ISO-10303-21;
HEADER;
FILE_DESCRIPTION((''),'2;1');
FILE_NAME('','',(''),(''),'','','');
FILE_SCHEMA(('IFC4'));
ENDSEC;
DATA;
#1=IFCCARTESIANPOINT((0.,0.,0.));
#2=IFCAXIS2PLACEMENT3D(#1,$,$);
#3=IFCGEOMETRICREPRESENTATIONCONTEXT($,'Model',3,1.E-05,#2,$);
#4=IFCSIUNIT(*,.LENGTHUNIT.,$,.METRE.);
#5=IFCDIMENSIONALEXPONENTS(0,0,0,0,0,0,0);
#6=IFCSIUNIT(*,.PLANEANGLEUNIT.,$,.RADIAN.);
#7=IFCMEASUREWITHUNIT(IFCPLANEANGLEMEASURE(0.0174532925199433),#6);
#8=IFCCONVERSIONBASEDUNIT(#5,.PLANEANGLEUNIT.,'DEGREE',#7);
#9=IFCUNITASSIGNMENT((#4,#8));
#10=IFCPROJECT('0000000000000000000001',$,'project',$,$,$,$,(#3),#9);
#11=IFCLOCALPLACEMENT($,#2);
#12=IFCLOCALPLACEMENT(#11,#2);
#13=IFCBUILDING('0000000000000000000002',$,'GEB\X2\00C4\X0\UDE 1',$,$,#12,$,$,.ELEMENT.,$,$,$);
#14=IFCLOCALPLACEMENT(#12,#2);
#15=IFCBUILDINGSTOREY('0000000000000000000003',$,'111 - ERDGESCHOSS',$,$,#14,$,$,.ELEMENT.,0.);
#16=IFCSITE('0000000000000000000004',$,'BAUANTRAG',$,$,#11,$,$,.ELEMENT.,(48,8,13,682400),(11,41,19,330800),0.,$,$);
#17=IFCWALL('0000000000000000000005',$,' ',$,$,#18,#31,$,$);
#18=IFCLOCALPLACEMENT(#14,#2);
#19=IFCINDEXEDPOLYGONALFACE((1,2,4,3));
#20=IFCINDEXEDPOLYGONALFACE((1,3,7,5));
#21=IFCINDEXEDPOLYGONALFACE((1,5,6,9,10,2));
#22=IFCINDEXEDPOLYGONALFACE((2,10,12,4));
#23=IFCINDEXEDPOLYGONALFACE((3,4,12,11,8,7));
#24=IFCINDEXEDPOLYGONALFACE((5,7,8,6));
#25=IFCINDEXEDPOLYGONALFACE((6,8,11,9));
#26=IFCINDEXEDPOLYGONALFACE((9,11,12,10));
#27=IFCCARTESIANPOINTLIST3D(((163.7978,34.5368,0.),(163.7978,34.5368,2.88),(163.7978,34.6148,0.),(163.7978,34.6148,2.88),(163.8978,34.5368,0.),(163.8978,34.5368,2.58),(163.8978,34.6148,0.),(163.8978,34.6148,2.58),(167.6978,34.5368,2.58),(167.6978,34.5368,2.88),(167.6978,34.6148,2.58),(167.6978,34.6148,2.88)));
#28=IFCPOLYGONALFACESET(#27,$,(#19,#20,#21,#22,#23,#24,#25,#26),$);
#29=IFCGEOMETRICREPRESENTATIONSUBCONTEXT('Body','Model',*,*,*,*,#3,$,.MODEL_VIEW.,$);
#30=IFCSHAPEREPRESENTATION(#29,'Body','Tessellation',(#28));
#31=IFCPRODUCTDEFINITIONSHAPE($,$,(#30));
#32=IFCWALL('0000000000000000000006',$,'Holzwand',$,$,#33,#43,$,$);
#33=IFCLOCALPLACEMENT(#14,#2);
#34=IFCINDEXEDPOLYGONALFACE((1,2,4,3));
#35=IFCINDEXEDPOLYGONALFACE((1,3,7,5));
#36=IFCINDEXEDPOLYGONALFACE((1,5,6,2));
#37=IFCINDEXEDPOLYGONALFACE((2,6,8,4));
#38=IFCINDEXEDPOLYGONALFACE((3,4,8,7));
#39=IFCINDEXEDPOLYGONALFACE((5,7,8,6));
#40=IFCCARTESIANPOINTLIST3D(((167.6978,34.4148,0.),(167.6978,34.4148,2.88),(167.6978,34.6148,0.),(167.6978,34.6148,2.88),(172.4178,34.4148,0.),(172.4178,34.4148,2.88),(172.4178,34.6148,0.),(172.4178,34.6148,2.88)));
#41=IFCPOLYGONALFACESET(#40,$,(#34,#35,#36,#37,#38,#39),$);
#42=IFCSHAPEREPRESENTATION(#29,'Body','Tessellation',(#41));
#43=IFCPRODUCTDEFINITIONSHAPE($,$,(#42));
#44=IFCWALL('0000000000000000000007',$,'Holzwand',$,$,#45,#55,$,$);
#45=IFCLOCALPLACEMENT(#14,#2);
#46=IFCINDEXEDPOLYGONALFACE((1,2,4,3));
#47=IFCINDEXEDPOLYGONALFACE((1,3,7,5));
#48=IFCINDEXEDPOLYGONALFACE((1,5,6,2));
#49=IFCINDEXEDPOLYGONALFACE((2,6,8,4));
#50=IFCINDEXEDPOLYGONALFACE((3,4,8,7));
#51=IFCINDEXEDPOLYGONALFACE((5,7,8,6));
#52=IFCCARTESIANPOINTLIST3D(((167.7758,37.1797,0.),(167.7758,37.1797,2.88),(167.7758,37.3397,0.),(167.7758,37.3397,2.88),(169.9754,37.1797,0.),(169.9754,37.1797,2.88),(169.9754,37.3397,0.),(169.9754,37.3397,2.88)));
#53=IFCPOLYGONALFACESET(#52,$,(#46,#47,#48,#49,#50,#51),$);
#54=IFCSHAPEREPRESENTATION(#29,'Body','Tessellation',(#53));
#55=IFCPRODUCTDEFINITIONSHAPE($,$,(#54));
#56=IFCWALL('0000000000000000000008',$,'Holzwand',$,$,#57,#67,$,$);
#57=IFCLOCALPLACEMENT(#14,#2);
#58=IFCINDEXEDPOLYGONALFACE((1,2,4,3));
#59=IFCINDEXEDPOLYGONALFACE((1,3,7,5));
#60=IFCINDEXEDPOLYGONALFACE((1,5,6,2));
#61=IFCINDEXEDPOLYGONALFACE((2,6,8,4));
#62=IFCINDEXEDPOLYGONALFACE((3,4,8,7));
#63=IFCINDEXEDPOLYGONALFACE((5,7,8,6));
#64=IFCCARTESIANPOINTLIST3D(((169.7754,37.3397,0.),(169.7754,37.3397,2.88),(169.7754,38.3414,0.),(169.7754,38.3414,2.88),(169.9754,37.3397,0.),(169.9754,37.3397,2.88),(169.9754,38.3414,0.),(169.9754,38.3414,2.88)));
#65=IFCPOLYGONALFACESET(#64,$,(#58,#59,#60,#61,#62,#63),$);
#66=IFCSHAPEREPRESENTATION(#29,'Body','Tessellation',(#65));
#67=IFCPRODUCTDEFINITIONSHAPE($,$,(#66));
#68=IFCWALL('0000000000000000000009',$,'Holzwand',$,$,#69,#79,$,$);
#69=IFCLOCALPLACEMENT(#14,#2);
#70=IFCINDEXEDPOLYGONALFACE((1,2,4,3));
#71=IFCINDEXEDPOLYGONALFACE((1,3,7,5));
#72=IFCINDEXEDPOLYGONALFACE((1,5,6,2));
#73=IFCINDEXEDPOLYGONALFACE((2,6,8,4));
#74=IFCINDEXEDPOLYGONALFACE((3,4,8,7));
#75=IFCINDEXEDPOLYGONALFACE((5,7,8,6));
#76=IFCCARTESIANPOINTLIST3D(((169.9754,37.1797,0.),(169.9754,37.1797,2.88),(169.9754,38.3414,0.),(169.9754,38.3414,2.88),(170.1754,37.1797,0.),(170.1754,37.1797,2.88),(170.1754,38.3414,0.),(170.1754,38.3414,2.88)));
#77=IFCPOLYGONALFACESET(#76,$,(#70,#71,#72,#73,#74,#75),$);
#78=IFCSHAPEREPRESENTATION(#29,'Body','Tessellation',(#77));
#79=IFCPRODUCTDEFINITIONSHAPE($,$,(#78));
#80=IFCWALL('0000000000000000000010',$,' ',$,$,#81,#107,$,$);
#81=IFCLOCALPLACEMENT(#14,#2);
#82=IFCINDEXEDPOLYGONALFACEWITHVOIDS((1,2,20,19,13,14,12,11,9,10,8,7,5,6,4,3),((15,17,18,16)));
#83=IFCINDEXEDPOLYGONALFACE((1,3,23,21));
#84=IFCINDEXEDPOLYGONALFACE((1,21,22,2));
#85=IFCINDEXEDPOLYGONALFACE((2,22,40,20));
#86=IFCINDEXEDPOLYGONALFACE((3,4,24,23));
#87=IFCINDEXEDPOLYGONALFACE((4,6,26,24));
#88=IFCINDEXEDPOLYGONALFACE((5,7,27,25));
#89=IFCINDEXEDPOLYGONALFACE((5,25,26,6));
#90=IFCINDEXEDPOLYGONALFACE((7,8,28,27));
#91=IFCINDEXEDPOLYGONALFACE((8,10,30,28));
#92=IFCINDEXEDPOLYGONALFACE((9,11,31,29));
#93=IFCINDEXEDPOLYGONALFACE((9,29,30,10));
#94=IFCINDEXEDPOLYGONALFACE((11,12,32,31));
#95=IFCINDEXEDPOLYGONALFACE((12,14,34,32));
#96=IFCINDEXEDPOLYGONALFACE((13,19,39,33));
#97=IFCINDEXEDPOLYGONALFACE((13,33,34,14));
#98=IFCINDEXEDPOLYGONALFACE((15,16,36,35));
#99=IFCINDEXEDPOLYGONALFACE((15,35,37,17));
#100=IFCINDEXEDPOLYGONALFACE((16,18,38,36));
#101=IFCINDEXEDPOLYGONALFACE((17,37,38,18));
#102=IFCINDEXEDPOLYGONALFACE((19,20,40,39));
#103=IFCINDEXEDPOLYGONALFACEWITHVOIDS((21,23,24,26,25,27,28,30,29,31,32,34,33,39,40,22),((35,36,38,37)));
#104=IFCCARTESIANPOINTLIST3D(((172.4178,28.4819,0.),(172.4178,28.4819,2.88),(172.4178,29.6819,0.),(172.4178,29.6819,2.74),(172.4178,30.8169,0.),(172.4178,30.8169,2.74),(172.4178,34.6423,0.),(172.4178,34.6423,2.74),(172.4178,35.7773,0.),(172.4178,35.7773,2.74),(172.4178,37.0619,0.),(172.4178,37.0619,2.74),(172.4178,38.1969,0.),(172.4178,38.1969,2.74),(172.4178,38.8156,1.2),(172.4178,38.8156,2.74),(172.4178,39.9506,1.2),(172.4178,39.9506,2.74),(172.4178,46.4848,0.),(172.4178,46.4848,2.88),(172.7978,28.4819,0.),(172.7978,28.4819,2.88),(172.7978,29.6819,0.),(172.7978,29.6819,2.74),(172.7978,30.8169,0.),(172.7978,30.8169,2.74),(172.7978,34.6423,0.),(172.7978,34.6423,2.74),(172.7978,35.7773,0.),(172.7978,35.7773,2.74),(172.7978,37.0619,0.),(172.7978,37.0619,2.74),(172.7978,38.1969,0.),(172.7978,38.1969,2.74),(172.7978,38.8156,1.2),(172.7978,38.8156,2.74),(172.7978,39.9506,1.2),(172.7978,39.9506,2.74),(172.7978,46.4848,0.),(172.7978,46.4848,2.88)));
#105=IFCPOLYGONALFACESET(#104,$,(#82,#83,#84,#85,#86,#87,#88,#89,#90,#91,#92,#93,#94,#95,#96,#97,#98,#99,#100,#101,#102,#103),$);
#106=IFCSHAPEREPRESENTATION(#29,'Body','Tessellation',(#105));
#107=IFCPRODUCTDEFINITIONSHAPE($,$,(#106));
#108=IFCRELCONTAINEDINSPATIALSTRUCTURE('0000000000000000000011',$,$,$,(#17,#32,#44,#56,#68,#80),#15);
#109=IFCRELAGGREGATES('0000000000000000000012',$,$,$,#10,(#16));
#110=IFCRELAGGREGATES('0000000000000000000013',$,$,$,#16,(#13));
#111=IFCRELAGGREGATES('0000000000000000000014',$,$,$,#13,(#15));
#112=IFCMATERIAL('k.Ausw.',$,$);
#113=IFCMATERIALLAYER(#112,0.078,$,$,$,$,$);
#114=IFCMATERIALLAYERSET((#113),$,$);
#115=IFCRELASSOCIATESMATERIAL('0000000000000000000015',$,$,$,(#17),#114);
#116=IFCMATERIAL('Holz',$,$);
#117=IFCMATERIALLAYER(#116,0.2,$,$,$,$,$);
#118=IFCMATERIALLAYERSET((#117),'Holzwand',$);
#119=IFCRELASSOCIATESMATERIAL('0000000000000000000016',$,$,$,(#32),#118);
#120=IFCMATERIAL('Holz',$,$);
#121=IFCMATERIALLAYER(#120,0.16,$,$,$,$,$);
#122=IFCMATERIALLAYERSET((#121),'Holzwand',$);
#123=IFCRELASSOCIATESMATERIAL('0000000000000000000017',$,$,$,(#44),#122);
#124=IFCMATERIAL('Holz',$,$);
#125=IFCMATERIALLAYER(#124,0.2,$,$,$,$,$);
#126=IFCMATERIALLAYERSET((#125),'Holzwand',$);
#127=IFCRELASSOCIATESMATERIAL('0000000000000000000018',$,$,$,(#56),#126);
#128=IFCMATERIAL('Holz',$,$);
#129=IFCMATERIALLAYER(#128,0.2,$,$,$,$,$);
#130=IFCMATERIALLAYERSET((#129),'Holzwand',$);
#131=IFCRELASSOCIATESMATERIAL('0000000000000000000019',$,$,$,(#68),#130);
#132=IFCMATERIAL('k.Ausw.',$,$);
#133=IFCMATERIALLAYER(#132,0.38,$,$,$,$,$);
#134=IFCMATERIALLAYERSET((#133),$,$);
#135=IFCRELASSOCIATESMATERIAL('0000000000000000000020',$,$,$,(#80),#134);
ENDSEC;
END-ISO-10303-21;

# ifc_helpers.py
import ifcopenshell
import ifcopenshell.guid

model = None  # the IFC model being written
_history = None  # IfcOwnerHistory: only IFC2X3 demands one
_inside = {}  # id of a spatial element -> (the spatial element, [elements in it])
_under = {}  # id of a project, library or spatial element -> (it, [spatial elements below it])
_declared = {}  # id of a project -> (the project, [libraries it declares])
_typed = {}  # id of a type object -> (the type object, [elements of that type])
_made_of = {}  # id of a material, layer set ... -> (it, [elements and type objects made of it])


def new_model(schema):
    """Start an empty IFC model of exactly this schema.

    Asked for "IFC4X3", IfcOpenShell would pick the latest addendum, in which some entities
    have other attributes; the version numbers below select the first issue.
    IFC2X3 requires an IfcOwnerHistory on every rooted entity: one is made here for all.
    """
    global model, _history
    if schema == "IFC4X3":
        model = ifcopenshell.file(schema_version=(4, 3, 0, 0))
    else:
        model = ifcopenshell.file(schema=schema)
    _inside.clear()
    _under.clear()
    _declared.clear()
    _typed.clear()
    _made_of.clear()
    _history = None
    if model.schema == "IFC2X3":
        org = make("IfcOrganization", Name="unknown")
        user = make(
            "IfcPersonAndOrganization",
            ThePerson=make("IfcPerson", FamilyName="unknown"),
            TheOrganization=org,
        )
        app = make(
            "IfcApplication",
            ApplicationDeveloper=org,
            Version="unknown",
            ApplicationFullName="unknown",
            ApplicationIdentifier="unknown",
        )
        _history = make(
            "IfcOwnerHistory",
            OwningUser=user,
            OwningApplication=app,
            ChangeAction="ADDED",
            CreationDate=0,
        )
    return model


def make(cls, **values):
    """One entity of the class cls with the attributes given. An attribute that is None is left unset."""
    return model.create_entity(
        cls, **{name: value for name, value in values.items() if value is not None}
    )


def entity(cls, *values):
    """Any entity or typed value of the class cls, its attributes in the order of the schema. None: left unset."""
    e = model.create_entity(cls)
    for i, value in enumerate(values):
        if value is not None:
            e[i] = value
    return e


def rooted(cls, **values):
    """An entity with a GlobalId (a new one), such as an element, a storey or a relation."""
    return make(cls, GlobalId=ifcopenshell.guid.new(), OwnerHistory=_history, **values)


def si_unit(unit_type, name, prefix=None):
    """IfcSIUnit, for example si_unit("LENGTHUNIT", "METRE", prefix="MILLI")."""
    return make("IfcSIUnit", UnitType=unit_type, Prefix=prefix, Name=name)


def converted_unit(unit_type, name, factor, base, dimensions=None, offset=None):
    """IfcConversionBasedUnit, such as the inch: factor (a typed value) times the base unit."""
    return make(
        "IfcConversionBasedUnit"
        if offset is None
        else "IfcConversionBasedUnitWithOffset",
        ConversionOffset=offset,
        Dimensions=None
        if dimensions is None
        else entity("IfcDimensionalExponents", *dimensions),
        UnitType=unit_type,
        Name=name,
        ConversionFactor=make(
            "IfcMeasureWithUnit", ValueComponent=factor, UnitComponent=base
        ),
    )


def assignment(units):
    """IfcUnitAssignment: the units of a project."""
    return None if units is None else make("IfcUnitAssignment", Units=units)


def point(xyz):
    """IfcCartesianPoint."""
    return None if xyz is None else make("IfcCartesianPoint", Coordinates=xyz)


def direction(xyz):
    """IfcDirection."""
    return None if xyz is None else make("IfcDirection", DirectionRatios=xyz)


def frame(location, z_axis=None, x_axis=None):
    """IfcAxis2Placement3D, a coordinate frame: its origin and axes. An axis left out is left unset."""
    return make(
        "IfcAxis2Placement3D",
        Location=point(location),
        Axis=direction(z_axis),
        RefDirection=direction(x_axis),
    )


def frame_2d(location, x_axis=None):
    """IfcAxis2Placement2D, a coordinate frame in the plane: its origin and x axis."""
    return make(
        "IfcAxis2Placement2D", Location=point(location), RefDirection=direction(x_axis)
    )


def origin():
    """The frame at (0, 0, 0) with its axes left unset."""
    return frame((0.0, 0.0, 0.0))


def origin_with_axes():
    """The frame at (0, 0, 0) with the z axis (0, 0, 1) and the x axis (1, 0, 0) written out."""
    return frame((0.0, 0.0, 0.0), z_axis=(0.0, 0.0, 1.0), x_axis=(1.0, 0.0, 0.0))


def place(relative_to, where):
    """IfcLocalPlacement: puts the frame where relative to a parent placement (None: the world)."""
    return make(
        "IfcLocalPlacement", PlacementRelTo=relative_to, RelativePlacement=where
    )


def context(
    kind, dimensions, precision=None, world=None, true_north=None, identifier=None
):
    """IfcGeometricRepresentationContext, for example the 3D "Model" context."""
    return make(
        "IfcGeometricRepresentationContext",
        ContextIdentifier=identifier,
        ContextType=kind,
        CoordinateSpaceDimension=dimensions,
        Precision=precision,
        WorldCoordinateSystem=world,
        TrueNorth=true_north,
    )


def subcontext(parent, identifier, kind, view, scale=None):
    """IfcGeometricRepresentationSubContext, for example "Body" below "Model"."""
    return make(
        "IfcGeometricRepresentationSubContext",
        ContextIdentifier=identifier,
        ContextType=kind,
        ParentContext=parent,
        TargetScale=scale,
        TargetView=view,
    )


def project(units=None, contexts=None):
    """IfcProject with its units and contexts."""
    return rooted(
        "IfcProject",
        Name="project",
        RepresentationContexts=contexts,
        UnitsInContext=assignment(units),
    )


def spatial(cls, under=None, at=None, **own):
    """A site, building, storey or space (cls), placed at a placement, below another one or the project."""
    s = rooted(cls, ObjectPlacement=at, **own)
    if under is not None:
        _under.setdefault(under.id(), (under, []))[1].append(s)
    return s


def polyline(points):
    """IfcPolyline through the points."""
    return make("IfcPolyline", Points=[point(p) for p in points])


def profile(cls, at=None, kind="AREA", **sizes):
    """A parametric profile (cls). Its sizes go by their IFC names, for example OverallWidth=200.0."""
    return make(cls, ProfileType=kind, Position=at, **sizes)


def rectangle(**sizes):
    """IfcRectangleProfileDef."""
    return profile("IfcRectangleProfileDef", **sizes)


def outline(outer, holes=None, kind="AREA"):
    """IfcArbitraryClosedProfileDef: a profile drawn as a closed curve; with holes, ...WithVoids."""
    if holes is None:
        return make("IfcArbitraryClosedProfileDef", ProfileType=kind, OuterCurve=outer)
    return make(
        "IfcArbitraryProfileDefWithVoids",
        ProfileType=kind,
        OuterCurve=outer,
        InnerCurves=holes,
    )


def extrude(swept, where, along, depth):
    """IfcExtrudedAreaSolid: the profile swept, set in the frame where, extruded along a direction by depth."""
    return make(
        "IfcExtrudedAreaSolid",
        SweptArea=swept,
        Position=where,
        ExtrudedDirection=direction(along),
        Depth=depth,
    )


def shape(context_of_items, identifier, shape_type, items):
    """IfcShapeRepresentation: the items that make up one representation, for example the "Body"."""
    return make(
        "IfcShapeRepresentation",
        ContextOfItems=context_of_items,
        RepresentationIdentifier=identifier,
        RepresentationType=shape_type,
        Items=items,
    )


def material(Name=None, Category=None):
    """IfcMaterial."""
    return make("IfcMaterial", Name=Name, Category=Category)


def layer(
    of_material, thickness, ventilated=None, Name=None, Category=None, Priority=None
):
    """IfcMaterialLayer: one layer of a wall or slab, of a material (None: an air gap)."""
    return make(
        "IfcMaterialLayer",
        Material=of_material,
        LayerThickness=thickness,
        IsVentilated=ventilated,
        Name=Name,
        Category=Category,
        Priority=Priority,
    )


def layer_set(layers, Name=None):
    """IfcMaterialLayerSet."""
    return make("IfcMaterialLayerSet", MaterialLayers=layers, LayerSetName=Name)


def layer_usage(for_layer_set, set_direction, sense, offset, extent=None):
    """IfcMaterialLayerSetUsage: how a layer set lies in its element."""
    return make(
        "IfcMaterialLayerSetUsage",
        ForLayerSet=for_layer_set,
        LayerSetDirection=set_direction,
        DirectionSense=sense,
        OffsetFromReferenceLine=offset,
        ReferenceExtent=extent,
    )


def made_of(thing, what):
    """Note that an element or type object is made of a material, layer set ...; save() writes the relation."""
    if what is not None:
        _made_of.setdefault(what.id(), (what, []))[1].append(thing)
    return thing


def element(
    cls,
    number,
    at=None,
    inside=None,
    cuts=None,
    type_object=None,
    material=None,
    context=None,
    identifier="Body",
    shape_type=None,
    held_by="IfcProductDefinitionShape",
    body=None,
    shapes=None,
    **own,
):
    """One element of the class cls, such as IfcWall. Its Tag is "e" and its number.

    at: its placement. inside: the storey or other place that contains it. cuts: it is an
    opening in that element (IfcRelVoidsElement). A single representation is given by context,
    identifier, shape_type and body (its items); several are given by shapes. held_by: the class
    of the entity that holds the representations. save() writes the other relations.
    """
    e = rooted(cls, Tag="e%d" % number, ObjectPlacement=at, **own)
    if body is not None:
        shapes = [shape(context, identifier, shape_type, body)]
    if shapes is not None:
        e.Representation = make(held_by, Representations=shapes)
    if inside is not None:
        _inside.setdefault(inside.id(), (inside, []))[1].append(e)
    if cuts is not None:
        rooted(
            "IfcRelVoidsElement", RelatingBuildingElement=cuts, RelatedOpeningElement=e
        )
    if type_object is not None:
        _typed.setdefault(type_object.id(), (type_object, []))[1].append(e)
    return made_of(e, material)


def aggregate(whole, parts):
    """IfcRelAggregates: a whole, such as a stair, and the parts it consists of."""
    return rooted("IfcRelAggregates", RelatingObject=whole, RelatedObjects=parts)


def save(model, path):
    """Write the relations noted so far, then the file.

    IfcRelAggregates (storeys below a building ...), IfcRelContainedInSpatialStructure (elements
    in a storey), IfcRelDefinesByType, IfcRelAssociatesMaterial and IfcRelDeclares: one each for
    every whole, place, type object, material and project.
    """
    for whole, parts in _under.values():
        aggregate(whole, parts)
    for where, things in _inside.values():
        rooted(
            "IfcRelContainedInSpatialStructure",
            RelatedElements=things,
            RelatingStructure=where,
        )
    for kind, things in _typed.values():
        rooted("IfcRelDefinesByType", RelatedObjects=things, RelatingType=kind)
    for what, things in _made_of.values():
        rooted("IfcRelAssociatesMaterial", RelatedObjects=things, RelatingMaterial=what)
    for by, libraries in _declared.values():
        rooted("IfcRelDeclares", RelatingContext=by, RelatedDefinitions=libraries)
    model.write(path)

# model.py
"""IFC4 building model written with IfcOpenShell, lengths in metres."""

from ifc_helpers import new_model, entity, si_unit, converted_unit, frame, frame_2d, origin, origin_with_axes, place, context, subcontext, project, spatial, polyline, rectangle, outline, extrude, material, layer, layer_set, layer_usage, element, save


model = new_model("IFC4")

# Units and contexts
model_context = context("Model", 3, precision=1e-05, world=origin())
body_context = subcontext(model_context, "Body", "Model", "MODEL_VIEW")
ifc_project = project(units=[si_unit("LENGTHUNIT", "METRE"), converted_unit("PLANEANGLEUNIT", "DEGREE", entity("IfcPlaneAngleMeasure", 0.0174532925199433), si_unit("PLANEANGLEUNIT", "RADIAN"), dimensions=[0, 0, 0, 0, 0, 0, 0])], contexts=[model_context])

# Site, building, storey
site_placement = place(None, origin())
site = spatial("IfcSite", under=ifc_project, at=site_placement, Name="BAUANTRAG", CompositionType="ELEMENT", RefLatitude=(48, 8, 13, 682400), RefLongitude=(11, 41, 19, 330800), RefElevation=0.0)
building_placement = place(site_placement, origin())
building = spatial("IfcBuilding", under=site, at=building_placement, Name="GEBÄUDE 1", CompositionType="ELEMENT")
storey_placement = place(building_placement, origin())
storey = spatial("IfcBuildingStorey", under=building, at=storey_placement, Name="111 - ERDGESCHOSS", CompositionType="ELEMENT", Elevation=0.0)

# Wall, opening
ifc_material_1 = material(Name="k.Ausw.")
ifc_layer_1 = layer(ifc_material_1, 0.078)
ifc_layer_set_1 = layer_set([ifc_layer_1])
ifc_layer_usage_1 = layer_usage(ifc_layer_set_1, "AXIS2", "POSITIVE", 0.0)
wall_1_placement = place(storey_placement, frame((163.7978, 34.5368, 0.0)))
wall_1 = element("IfcWall", 1, at=wall_1_placement, inside=storey, material=ifc_layer_usage_1, Name=" ", context=body_context, shape_type="SweptSolid", body=[
    extrude(rectangle(XDim=3.9, YDim=0.078, at=frame_2d((1.95, 0.039), x_axis=(1.0, 0.0))), origin_with_axes(), (0.0, 0.0, 1.0), 2.88),
])
opening_1_placement = place(wall_1_placement, frame((0.1, 0.0, -0.14), z_axis=(0.0, 1.0, 0.0), x_axis=(0.0, 0.0, 1.0)))
element("IfcOpeningElement", 2, at=opening_1_placement, cuts=wall_1, ObjectType="Opening", context=body_context, shape_type="SweptSolid", body=[
    extrude(outline(polyline([(0.0, 3.8), (2.72, 3.8), (2.72, 0.0), (0.0, 0.0), (0.0, 3.8)])), origin_with_axes(), (0.0, 0.0, 1.0), 0.078),
])

# Walls
ifc_material_2 = material(Name="Holz")
ifc_layer_2 = layer(ifc_material_2, 0.2)
ifc_layer_set_2 = layer_set([ifc_layer_2], Name="Holzwand")
ifc_layer_usage_2 = layer_usage(ifc_layer_set_2, "AXIS2", "POSITIVE", 0.0)
wall_2_placement = place(storey_placement, frame((167.6978, 34.4148, 0.0)))
element("IfcWall", 3, at=wall_2_placement, inside=storey, material=ifc_layer_usage_2, Name="Holzwand", context=body_context, shape_type="SweptSolid", body=[
    extrude(rectangle(XDim=4.72, YDim=0.2, at=frame_2d((2.36, 0.1), x_axis=(1.0, 0.0))), origin_with_axes(), (0.0, 0.0, 1.0), 2.88),
])
ifc_material_3 = material(Name="Holz")
ifc_layer_3 = layer(ifc_material_3, 0.16)
ifc_layer_set_3 = layer_set([ifc_layer_3], Name="Holzwand")
ifc_layer_usage_3 = layer_usage(ifc_layer_set_3, "AXIS2", "POSITIVE", 0.0)
wall_3_placement = place(storey_placement, frame((169.9754, 37.3397, 0.0), z_axis=(0.0, 0.0, 1.0), x_axis=(-1.0, 0.0, 0.0)))
element("IfcWall", 4, at=wall_3_placement, inside=storey, material=ifc_layer_usage_3, Name="Holzwand", context=body_context, shape_type="SweptSolid", body=[
    extrude(rectangle(XDim=2.1997, YDim=0.16, at=frame_2d((1.0998, 0.08), x_axis=(1.0, 0.0))), origin_with_axes(), (0.0, 0.0, 1.0), 2.88),
])
ifc_material_4 = material(Name="Holz")
ifc_layer_4 = layer(ifc_material_4, 0.2)
ifc_layer_set_4 = layer_set([ifc_layer_4], Name="Holzwand")
ifc_layer_usage_4 = layer_usage(ifc_layer_set_4, "AXIS2", "POSITIVE", 0.0)
wall_4_placement = place(storey_placement, frame((169.9754, 37.3397, 0.0), z_axis=(0.0, 0.0, 1.0), x_axis=(0.0, 1.0, 0.0)))
element("IfcWall", 5, at=wall_4_placement, inside=storey, material=ifc_layer_usage_4, Name="Holzwand", context=body_context, shape_type="SweptSolid", body=[
    extrude(rectangle(XDim=1.0017, YDim=0.2, at=frame_2d((0.5008, 0.1), x_axis=(1.0, 0.0))), origin_with_axes(), (0.0, 0.0, 1.0), 2.88),
])
ifc_material_5 = material(Name="Holz")
ifc_layer_5 = layer(ifc_material_5, 0.2)
ifc_layer_set_5 = layer_set([ifc_layer_5], Name="Holzwand")
ifc_layer_usage_5 = layer_usage(ifc_layer_set_5, "AXIS2", "POSITIVE", 0.0)
wall_5_placement = place(storey_placement, frame((170.1754, 37.1797, 0.0), z_axis=(0.0, 0.0, 1.0), x_axis=(0.0, 1.0, 0.0)))
element("IfcWall", 6, at=wall_5_placement, inside=storey, material=ifc_layer_usage_5, Name="Holzwand", context=body_context, shape_type="SweptSolid", body=[
    extrude(rectangle(XDim=1.1617, YDim=0.2, at=frame_2d((0.5808, 0.1), x_axis=(1.0, 0.0))), origin_with_axes(), (0.0, 0.0, 1.0), 2.88),
])

# Wall, openings
ifc_material_6 = material(Name="k.Ausw.")
ifc_layer_6 = layer(ifc_material_6, 0.38)
ifc_layer_set_6 = layer_set([ifc_layer_6])
ifc_layer_usage_6 = layer_usage(ifc_layer_set_6, "AXIS2", "POSITIVE", 0.0)
wall_6_placement = place(storey_placement, frame((172.7978, 28.4819, 0.0), z_axis=(0.0, 0.0, 1.0), x_axis=(0.0, 1.0, 0.0)))
wall_6 = element("IfcWall", 7, at=wall_6_placement, inside=storey, material=ifc_layer_usage_6, Name=" ", context=body_context, shape_type="SweptSolid", body=[
    extrude(rectangle(XDim=18.0029, YDim=0.38, at=frame_2d((9.0014, 0.19), x_axis=(1.0, 0.0))), origin_with_axes(), (0.0, 0.0, 1.0), 2.88),
])
opening_2_placement = place(wall_6_placement, frame((10.3337, 0.0, 1.2), z_axis=(0.0, 1.0, 0.0), x_axis=(0.0, 0.0, 1.0)))
element("IfcOpeningElement", 8, at=opening_2_placement, cuts=wall_6, ObjectType="Opening", context=body_context, shape_type="SweptSolid", body=[
    extrude(outline(polyline([(0.0, 1.135), (1.54, 1.135), (1.54, 0.0), (0.0, 0.0), (0.0, 1.135)])), origin_with_axes(), (0.0, 0.0, 1.0), 0.38),
])
opening_3_placement = place(wall_6_placement, frame((8.58, 0.0, 0.0), z_axis=(0.0, 1.0, 0.0), x_axis=(0.0, 0.0, 1.0)))
element("IfcOpeningElement", 9, at=opening_3_placement, cuts=wall_6, ObjectType="Opening", context=body_context, shape_type="SweptSolid", body=[
    extrude(outline(polyline([(0.0, 1.135), (2.74, 1.135), (2.74, 0.0), (0.0, 0.0), (0.0, 1.135)])), origin_with_axes(), (0.0, 0.0, 1.0), 0.38),
])
opening_4_placement = place(wall_6_placement, frame((6.1604, 0.0, 0.0), z_axis=(0.0, 1.0, 0.0), x_axis=(0.0, 0.0, 1.0)))
element("IfcOpeningElement", 10, at=opening_4_placement, cuts=wall_6, ObjectType="Opening", context=body_context, shape_type="SweptSolid", body=[
    extrude(outline(polyline([(0.0, 1.135), (2.74, 1.135), (2.74, 0.0), (0.0, 0.0), (0.0, 1.135)])), origin_with_axes(), (0.0, 0.0, 1.0), 0.38),
])
opening_5_placement = place(wall_6_placement, frame((1.2, 0.0, 0.0), z_axis=(0.0, 1.0, 0.0), x_axis=(0.0, 0.0, 1.0)))
element("IfcOpeningElement", 11, at=opening_5_placement, cuts=wall_6, ObjectType="Opening", context=body_context, shape_type="SweptSolid", body=[
    extrude(outline(polyline([(0.0, 1.135), (2.74, 1.135), (2.74, 0.0), (0.0, 0.0), (0.0, 1.135)])), origin_with_axes(), (0.0, 0.0, 1.0), 0.38),
])

save(model, "model.ifc")
